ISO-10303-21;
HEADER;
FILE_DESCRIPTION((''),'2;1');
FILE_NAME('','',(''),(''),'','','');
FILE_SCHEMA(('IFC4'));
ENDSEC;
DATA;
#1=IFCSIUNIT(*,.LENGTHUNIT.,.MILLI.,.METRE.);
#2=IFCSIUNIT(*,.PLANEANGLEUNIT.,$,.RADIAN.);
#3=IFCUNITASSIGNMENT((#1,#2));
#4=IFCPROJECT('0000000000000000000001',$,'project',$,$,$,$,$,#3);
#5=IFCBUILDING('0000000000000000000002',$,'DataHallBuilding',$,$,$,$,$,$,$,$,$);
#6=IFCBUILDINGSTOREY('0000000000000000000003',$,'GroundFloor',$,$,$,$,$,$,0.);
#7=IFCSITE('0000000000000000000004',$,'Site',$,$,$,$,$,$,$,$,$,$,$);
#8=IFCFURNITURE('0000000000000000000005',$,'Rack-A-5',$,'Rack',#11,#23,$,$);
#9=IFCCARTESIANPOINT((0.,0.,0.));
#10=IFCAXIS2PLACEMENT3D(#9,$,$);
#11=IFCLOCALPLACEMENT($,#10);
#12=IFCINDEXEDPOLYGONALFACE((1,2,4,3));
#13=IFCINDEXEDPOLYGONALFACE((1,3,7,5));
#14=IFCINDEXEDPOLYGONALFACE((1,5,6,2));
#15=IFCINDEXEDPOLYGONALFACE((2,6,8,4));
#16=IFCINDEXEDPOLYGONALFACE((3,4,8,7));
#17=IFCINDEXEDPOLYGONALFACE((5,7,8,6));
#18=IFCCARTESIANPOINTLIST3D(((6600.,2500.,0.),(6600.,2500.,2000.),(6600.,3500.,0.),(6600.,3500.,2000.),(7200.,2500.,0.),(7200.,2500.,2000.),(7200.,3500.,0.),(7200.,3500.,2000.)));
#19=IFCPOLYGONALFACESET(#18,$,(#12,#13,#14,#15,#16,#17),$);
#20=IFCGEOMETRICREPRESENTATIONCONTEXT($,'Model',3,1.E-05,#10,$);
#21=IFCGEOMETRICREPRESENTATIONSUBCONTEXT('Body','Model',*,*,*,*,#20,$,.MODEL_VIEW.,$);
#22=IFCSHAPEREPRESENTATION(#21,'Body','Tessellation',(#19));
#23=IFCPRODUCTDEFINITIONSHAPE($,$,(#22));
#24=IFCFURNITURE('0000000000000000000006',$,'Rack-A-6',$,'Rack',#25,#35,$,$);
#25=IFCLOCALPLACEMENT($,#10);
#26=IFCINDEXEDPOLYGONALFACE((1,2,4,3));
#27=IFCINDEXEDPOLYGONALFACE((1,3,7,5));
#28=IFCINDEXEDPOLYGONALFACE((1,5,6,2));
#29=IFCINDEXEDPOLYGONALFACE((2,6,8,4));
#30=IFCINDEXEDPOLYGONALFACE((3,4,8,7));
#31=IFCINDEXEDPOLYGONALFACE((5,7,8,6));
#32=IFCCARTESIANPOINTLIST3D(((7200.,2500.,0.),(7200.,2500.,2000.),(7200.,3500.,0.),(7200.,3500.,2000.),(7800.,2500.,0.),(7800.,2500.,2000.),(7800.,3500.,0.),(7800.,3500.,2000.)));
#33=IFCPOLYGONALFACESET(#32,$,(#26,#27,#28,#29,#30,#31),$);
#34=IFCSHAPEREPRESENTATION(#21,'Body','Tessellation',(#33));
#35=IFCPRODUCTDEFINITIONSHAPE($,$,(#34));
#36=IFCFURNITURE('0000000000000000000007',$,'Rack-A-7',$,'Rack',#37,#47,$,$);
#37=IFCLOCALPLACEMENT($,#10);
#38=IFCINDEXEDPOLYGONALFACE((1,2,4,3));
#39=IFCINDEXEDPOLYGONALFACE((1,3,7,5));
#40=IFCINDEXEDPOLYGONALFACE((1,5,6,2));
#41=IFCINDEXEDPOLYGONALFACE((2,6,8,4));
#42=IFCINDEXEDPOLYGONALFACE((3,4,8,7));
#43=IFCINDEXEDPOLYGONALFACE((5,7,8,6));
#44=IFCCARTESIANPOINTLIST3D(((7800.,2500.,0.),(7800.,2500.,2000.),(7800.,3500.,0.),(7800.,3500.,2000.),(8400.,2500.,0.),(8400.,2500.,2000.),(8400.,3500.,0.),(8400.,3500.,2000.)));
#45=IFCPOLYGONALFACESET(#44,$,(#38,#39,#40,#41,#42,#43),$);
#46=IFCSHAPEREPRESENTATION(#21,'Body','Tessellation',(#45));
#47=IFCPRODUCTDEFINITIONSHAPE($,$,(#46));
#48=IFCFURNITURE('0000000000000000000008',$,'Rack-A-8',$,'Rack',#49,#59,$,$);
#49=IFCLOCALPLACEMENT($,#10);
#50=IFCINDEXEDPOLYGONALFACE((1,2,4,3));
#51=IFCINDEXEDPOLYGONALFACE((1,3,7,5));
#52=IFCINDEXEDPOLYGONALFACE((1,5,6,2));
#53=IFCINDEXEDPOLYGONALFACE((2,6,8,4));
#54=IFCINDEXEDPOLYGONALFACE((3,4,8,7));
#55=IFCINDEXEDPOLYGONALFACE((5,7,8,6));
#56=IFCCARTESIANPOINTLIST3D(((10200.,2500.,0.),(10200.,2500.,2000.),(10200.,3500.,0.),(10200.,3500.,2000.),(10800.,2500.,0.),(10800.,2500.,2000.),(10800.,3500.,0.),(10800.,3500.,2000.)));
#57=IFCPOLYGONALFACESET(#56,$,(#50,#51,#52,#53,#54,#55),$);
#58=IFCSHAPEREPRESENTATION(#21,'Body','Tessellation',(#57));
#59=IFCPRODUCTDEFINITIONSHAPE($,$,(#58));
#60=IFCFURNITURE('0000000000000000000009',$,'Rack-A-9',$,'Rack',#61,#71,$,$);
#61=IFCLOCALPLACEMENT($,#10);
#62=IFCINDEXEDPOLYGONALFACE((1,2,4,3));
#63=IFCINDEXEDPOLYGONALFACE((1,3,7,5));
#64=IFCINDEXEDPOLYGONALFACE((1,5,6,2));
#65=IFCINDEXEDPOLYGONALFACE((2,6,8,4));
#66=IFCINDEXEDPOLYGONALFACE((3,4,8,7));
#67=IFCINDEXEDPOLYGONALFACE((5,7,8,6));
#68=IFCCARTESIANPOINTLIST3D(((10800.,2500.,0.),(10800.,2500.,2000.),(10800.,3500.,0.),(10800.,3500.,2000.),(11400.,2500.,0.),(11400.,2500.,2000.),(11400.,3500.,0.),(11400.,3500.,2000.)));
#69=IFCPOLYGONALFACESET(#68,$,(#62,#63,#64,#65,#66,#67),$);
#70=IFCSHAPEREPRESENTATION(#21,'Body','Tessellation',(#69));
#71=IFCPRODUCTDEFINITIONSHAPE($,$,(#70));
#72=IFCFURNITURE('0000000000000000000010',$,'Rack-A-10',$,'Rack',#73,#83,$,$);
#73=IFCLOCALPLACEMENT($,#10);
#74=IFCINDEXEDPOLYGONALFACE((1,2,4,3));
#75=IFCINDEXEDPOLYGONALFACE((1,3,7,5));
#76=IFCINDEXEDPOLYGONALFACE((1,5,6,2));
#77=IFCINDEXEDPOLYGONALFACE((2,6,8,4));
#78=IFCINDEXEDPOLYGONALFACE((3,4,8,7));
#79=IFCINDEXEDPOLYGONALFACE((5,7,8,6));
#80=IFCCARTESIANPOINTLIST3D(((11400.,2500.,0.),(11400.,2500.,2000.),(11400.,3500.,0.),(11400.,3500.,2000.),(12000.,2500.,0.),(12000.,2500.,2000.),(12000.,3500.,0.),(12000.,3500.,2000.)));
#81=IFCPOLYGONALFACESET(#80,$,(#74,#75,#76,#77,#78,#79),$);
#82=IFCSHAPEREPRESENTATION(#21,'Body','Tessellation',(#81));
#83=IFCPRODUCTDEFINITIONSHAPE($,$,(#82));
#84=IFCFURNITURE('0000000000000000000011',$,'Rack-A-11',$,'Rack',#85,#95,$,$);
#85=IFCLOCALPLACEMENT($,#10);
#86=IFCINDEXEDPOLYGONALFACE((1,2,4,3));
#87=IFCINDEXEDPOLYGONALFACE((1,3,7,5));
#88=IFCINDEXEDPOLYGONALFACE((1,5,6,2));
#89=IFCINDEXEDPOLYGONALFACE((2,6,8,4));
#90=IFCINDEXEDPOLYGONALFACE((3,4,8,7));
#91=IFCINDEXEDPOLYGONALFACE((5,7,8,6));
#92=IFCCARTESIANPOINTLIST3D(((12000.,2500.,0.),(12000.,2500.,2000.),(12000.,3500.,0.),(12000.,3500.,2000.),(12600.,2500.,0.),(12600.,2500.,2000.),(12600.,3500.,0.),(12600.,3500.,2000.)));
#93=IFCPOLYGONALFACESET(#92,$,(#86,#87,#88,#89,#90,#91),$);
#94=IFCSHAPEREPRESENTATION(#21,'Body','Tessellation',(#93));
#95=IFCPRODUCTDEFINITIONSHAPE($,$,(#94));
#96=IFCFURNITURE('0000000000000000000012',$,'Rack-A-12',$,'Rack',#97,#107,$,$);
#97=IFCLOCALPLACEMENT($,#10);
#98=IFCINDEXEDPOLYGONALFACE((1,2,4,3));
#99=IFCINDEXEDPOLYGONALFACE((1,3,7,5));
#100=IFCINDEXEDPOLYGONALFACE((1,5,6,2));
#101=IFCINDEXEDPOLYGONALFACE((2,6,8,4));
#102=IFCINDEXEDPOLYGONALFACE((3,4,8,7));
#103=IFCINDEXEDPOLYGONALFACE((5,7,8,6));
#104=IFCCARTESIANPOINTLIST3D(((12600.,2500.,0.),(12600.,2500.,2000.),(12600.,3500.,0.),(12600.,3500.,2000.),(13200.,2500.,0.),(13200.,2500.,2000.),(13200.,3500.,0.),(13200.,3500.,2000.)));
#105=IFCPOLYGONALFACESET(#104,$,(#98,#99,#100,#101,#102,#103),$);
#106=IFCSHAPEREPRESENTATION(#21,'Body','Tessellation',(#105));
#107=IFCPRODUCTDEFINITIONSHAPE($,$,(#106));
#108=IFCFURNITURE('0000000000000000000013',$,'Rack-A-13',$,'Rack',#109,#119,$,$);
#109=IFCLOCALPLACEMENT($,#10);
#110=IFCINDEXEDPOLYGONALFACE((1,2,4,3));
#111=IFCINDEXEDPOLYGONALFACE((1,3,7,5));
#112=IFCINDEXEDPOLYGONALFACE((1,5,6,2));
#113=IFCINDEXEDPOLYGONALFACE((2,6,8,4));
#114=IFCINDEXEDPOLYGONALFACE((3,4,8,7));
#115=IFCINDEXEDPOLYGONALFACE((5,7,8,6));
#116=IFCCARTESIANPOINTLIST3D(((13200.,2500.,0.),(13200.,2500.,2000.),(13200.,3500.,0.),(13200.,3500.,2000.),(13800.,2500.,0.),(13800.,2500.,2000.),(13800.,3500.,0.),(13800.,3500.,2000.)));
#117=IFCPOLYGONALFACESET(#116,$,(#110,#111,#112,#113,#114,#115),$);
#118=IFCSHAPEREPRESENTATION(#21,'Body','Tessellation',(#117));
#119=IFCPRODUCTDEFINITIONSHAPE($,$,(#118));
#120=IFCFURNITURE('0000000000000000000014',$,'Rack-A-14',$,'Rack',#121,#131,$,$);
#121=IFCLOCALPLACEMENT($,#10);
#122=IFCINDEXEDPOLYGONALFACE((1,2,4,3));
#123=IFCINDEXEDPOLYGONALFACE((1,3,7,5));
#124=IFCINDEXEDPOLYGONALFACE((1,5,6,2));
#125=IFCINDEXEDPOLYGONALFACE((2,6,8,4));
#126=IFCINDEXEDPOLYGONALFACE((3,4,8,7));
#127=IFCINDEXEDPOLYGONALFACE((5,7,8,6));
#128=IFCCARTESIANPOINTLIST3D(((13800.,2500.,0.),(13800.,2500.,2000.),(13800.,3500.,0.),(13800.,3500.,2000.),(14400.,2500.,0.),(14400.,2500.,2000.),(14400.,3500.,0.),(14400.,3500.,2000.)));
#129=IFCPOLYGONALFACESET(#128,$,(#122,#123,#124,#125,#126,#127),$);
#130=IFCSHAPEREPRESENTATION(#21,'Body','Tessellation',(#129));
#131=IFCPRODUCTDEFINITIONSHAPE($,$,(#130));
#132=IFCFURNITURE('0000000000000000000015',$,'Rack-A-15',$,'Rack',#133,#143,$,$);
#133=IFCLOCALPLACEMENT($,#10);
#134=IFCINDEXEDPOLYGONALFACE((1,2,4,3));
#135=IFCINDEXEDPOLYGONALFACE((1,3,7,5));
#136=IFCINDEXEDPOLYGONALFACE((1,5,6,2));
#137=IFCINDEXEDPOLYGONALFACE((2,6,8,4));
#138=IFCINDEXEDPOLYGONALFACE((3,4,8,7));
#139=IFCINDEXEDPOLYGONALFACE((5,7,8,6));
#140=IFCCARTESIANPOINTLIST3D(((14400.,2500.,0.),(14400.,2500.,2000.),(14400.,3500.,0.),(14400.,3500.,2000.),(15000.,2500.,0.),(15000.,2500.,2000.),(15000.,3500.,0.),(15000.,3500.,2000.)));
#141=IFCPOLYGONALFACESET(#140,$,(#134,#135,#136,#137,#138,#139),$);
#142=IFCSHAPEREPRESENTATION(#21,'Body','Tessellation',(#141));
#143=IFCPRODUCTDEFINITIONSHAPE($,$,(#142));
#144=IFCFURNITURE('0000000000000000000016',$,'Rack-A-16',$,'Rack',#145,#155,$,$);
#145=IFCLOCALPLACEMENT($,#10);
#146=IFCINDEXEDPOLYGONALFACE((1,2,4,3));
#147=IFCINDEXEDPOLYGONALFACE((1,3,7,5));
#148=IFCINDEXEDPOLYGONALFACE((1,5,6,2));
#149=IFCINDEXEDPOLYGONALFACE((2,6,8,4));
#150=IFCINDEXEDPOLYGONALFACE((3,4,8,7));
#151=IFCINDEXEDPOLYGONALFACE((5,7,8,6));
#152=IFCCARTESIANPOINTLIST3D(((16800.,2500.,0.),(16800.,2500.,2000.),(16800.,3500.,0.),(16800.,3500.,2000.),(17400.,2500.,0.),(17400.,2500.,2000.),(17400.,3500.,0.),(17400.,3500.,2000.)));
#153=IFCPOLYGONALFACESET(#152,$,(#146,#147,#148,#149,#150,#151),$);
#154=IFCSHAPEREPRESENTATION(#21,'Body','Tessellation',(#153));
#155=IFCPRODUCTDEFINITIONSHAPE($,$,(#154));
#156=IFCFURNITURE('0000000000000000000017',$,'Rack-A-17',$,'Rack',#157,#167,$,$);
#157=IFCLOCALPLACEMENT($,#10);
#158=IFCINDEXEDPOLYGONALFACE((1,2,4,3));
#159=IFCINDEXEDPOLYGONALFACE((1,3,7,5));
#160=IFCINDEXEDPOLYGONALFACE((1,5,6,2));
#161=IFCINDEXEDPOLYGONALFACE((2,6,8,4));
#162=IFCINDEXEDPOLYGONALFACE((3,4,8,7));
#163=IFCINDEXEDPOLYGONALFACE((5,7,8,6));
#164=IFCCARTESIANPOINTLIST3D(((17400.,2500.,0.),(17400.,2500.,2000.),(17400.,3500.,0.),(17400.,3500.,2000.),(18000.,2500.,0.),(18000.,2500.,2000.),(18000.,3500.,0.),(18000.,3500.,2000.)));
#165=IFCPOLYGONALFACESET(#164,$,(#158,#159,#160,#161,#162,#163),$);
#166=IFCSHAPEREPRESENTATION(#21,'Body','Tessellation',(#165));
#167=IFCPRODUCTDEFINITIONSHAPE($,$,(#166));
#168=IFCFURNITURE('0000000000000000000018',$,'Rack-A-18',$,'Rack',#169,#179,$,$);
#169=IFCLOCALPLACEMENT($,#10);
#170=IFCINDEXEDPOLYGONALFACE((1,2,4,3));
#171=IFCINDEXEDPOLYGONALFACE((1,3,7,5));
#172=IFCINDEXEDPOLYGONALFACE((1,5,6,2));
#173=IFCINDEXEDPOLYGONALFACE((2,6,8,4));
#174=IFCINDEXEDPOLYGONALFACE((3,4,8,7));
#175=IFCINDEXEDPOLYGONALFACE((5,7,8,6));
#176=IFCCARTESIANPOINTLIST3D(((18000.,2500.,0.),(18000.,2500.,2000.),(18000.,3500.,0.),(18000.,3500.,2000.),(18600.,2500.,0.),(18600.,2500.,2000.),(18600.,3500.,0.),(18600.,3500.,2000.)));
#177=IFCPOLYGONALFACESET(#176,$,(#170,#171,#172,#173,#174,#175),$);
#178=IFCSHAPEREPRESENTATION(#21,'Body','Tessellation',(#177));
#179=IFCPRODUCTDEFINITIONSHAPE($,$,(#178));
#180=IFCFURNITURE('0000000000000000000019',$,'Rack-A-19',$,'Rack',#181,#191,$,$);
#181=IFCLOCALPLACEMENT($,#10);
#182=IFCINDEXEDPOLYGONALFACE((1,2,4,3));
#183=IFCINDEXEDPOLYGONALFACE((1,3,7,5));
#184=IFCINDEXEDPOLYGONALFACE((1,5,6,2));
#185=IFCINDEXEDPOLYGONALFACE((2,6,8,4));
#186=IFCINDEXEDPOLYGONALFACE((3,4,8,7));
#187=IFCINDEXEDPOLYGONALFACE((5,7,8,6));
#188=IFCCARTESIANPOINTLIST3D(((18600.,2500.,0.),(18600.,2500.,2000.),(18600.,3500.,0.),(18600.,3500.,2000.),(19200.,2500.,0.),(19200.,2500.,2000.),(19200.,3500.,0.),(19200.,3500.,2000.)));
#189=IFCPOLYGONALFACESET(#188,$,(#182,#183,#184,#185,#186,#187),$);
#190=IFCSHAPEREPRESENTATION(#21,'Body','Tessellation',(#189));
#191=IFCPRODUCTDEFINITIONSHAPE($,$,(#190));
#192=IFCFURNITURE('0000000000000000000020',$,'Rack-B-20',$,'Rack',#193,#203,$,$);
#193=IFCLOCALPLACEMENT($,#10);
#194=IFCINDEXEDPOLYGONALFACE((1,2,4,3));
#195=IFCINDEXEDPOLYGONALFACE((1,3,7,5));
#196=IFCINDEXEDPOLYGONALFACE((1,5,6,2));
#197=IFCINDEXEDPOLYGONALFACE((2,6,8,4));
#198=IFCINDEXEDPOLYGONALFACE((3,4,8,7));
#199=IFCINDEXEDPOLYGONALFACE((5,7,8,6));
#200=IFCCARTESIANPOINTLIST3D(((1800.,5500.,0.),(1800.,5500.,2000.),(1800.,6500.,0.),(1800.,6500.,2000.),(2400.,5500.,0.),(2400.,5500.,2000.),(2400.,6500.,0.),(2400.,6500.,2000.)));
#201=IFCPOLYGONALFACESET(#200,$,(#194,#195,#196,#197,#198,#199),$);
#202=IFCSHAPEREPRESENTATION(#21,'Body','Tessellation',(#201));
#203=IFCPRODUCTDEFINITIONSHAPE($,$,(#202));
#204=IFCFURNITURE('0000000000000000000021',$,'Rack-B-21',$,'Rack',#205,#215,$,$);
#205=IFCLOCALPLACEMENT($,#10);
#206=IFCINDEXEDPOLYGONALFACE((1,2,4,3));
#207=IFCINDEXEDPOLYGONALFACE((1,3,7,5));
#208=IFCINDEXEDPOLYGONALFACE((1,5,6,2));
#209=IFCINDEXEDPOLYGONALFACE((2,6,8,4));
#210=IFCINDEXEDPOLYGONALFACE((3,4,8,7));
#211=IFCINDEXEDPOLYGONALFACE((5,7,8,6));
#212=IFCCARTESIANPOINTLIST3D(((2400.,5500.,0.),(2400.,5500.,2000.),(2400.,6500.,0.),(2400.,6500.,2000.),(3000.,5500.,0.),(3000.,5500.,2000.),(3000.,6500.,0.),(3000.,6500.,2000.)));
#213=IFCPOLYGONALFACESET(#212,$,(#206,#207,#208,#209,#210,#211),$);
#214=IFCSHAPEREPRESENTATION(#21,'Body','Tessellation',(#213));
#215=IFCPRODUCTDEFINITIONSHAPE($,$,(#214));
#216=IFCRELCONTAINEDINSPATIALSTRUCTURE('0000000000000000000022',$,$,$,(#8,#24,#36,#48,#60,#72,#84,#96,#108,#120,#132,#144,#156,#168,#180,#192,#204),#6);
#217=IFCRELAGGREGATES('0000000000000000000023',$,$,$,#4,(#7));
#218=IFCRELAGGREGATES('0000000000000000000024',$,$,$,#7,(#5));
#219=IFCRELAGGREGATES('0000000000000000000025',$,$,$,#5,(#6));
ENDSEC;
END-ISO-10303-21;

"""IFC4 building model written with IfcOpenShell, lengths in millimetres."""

from ifc_helpers import new_model, si_unit, frame, origin, place, context, subcontext, project, spatial, rectangle, extrude, element, save


model = new_model("IFC4")

# Units and contexts
model_context = context("Model", 3, precision=1e-05, world=origin())
body_context = subcontext(model_context, "Body", "Model", "MODEL_VIEW")
ifc_project = project(units=[si_unit("LENGTHUNIT", "METRE", prefix="MILLI"), si_unit("PLANEANGLEUNIT", "RADIAN")])

# Site, building, storey
site = spatial("IfcSite", under=ifc_project, Name="Site")
building = spatial("IfcBuilding", under=site, Name="DataHallBuilding")
storey = spatial("IfcBuildingStorey", under=building, Name="GroundFloor", Elevation=0.0)

# Furniture
furniture_1_placement = place(None, origin())
element("IfcFurniture", 1, at=furniture_1_placement, inside=storey, Name="Rack-A-5", ObjectType="Rack", context=body_context, shape_type="SweptSolid", body=[
    extrude(rectangle(XDim=600.0, YDim=1000.0), frame((6900.0, 3000.0, 0.0), z_axis=(0.0, 0.0, 1.0), x_axis=(1.0, 0.0, 0.0)), (0.0, 0.0, 1.0), 2000.0),
])
furniture_2_placement = place(None, origin())
element("IfcFurniture", 2, at=furniture_2_placement, inside=storey, Name="Rack-A-6", ObjectType="Rack", context=body_context, shape_type="SweptSolid", body=[
    extrude(rectangle(XDim=600.0, YDim=1000.0), frame((7500.0, 3000.0, 0.0), z_axis=(0.0, 0.0, 1.0), x_axis=(1.0, 0.0, 0.0)), (0.0, 0.0, 1.0), 2000.0),
])
furniture_3_placement = place(None, origin())
element("IfcFurniture", 3, at=furniture_3_placement, inside=storey, Name="Rack-A-7", ObjectType="Rack", context=body_context, shape_type="SweptSolid", body=[
    extrude(rectangle(XDim=600.0, YDim=1000.0), frame((8100.0, 3000.0, 0.0), z_axis=(0.0, 0.0, 1.0), x_axis=(1.0, 0.0, 0.0)), (0.0, 0.0, 1.0), 2000.0),
])
furniture_4_placement = place(None, origin())
element("IfcFurniture", 4, at=furniture_4_placement, inside=storey, Name="Rack-A-8", ObjectType="Rack", context=body_context, shape_type="SweptSolid", body=[
    extrude(rectangle(XDim=600.0, YDim=1000.0), frame((10500.0, 3000.0, 0.0), z_axis=(0.0, 0.0, 1.0), x_axis=(1.0, 0.0, 0.0)), (0.0, 0.0, 1.0), 2000.0),
])
furniture_5_placement = place(None, origin())
element("IfcFurniture", 5, at=furniture_5_placement, inside=storey, Name="Rack-A-9", ObjectType="Rack", context=body_context, shape_type="SweptSolid", body=[
    extrude(rectangle(XDim=600.0, YDim=1000.0), frame((11100.0, 3000.0, 0.0), z_axis=(0.0, 0.0, 1.0), x_axis=(1.0, 0.0, 0.0)), (0.0, 0.0, 1.0), 2000.0),
])
furniture_6_placement = place(None, origin())
element("IfcFurniture", 6, at=furniture_6_placement, inside=storey, Name="Rack-A-10", ObjectType="Rack", context=body_context, shape_type="SweptSolid", body=[
    extrude(rectangle(XDim=600.0, YDim=1000.0), frame((11700.0, 3000.0, 0.0), z_axis=(0.0, 0.0, 1.0), x_axis=(1.0, 0.0, 0.0)), (0.0, 0.0, 1.0), 2000.0),
])
furniture_7_placement = place(None, origin())
element("IfcFurniture", 7, at=furniture_7_placement, inside=storey, Name="Rack-A-11", ObjectType="Rack", context=body_context, shape_type="SweptSolid", body=[
    extrude(rectangle(XDim=600.0, YDim=1000.0), frame((12300.0, 3000.0, 0.0), z_axis=(0.0, 0.0, 1.0), x_axis=(1.0, 0.0, 0.0)), (0.0, 0.0, 1.0), 2000.0),
])
furniture_8_placement = place(None, origin())
element("IfcFurniture", 8, at=furniture_8_placement, inside=storey, Name="Rack-A-12", ObjectType="Rack", context=body_context, shape_type="SweptSolid", body=[
    extrude(rectangle(XDim=600.0, YDim=1000.0), frame((12900.0, 3000.0, 0.0), z_axis=(0.0, 0.0, 1.0), x_axis=(1.0, 0.0, 0.0)), (0.0, 0.0, 1.0), 2000.0),
])
furniture_9_placement = place(None, origin())
element("IfcFurniture", 9, at=furniture_9_placement, inside=storey, Name="Rack-A-13", ObjectType="Rack", context=body_context, shape_type="SweptSolid", body=[
    extrude(rectangle(XDim=600.0, YDim=1000.0), frame((13500.0, 3000.0, 0.0), z_axis=(0.0, 0.0, 1.0), x_axis=(1.0, 0.0, 0.0)), (0.0, 0.0, 1.0), 2000.0),
])
furniture_10_placement = place(None, origin())
element("IfcFurniture", 10, at=furniture_10_placement, inside=storey, Name="Rack-A-14", ObjectType="Rack", context=body_context, shape_type="SweptSolid", body=[
    extrude(rectangle(XDim=600.0, YDim=1000.0), frame((14100.0, 3000.0, 0.0), z_axis=(0.0, 0.0, 1.0), x_axis=(1.0, 0.0, 0.0)), (0.0, 0.0, 1.0), 2000.0),
])
furniture_11_placement = place(None, origin())
element("IfcFurniture", 11, at=furniture_11_placement, inside=storey, Name="Rack-A-15", ObjectType="Rack", context=body_context, shape_type="SweptSolid", body=[
    extrude(rectangle(XDim=600.0, YDim=1000.0), frame((14700.0, 3000.0, 0.0), z_axis=(0.0, 0.0, 1.0), x_axis=(1.0, 0.0, 0.0)), (0.0, 0.0, 1.0), 2000.0),
])
furniture_12_placement = place(None, origin())
element("IfcFurniture", 12, at=furniture_12_placement, inside=storey, Name="Rack-A-16", ObjectType="Rack", context=body_context, shape_type="SweptSolid", body=[
    extrude(rectangle(XDim=600.0, YDim=1000.0), frame((17100.0, 3000.0, 0.0), z_axis=(0.0, 0.0, 1.0), x_axis=(1.0, 0.0, 0.0)), (0.0, 0.0, 1.0), 2000.0),
])
furniture_13_placement = place(None, origin())
element("IfcFurniture", 13, at=furniture_13_placement, inside=storey, Name="Rack-A-17", ObjectType="Rack", context=body_context, shape_type="SweptSolid", body=[
    extrude(rectangle(XDim=600.0, YDim=1000.0), frame((17700.0, 3000.0, 0.0), z_axis=(0.0, 0.0, 1.0), x_axis=(1.0, 0.0, 0.0)), (0.0, 0.0, 1.0), 2000.0),
])
furniture_14_placement = place(None, origin())
element("IfcFurniture", 14, at=furniture_14_placement, inside=storey, Name="Rack-A-18", ObjectType="Rack", context=body_context, shape_type="SweptSolid", body=[
    extrude(rectangle(XDim=600.0, YDim=1000.0), frame((18300.0, 3000.0, 0.0), z_axis=(0.0, 0.0, 1.0), x_axis=(1.0, 0.0, 0.0)), (0.0, 0.0, 1.0), 2000.0),
])
furniture_15_placement = place(None, origin())
element("IfcFurniture", 15, at=furniture_15_placement, inside=storey, Name="Rack-A-19", ObjectType="Rack", context=body_context, shape_type="SweptSolid", body=[
    extrude(rectangle(XDim=600.0, YDim=1000.0), frame((18900.0, 3000.0, 0.0), z_axis=(0.0, 0.0, 1.0), x_axis=(1.0, 0.0, 0.0)), (0.0, 0.0, 1.0), 2000.0),
])
furniture_16_placement = place(None, origin())
element("IfcFurniture", 16, at=furniture_16_placement, inside=storey, Name="Rack-B-20", ObjectType="Rack", context=body_context, shape_type="SweptSolid", body=[
    extrude(rectangle(XDim=600.0, YDim=1000.0), frame((2100.0, 6000.0, 0.0), z_axis=(0.0, 0.0, 1.0), x_axis=(1.0, 0.0, 0.0)), (0.0, 0.0, 1.0), 2000.0),
])
furniture_17_placement = place(None, origin())
element("IfcFurniture", 17, at=furniture_17_placement, inside=storey, Name="Rack-B-21", ObjectType="Rack", context=body_context, shape_type="SweptSolid", body=[
    extrude(rectangle(XDim=600.0, YDim=1000.0), frame((2700.0, 6000.0, 0.0), z_axis=(0.0, 0.0, 1.0), x_axis=(1.0, 0.0, 0.0)), (0.0, 0.0, 1.0), 2000.0),
])

save(model, "model.ifc")
